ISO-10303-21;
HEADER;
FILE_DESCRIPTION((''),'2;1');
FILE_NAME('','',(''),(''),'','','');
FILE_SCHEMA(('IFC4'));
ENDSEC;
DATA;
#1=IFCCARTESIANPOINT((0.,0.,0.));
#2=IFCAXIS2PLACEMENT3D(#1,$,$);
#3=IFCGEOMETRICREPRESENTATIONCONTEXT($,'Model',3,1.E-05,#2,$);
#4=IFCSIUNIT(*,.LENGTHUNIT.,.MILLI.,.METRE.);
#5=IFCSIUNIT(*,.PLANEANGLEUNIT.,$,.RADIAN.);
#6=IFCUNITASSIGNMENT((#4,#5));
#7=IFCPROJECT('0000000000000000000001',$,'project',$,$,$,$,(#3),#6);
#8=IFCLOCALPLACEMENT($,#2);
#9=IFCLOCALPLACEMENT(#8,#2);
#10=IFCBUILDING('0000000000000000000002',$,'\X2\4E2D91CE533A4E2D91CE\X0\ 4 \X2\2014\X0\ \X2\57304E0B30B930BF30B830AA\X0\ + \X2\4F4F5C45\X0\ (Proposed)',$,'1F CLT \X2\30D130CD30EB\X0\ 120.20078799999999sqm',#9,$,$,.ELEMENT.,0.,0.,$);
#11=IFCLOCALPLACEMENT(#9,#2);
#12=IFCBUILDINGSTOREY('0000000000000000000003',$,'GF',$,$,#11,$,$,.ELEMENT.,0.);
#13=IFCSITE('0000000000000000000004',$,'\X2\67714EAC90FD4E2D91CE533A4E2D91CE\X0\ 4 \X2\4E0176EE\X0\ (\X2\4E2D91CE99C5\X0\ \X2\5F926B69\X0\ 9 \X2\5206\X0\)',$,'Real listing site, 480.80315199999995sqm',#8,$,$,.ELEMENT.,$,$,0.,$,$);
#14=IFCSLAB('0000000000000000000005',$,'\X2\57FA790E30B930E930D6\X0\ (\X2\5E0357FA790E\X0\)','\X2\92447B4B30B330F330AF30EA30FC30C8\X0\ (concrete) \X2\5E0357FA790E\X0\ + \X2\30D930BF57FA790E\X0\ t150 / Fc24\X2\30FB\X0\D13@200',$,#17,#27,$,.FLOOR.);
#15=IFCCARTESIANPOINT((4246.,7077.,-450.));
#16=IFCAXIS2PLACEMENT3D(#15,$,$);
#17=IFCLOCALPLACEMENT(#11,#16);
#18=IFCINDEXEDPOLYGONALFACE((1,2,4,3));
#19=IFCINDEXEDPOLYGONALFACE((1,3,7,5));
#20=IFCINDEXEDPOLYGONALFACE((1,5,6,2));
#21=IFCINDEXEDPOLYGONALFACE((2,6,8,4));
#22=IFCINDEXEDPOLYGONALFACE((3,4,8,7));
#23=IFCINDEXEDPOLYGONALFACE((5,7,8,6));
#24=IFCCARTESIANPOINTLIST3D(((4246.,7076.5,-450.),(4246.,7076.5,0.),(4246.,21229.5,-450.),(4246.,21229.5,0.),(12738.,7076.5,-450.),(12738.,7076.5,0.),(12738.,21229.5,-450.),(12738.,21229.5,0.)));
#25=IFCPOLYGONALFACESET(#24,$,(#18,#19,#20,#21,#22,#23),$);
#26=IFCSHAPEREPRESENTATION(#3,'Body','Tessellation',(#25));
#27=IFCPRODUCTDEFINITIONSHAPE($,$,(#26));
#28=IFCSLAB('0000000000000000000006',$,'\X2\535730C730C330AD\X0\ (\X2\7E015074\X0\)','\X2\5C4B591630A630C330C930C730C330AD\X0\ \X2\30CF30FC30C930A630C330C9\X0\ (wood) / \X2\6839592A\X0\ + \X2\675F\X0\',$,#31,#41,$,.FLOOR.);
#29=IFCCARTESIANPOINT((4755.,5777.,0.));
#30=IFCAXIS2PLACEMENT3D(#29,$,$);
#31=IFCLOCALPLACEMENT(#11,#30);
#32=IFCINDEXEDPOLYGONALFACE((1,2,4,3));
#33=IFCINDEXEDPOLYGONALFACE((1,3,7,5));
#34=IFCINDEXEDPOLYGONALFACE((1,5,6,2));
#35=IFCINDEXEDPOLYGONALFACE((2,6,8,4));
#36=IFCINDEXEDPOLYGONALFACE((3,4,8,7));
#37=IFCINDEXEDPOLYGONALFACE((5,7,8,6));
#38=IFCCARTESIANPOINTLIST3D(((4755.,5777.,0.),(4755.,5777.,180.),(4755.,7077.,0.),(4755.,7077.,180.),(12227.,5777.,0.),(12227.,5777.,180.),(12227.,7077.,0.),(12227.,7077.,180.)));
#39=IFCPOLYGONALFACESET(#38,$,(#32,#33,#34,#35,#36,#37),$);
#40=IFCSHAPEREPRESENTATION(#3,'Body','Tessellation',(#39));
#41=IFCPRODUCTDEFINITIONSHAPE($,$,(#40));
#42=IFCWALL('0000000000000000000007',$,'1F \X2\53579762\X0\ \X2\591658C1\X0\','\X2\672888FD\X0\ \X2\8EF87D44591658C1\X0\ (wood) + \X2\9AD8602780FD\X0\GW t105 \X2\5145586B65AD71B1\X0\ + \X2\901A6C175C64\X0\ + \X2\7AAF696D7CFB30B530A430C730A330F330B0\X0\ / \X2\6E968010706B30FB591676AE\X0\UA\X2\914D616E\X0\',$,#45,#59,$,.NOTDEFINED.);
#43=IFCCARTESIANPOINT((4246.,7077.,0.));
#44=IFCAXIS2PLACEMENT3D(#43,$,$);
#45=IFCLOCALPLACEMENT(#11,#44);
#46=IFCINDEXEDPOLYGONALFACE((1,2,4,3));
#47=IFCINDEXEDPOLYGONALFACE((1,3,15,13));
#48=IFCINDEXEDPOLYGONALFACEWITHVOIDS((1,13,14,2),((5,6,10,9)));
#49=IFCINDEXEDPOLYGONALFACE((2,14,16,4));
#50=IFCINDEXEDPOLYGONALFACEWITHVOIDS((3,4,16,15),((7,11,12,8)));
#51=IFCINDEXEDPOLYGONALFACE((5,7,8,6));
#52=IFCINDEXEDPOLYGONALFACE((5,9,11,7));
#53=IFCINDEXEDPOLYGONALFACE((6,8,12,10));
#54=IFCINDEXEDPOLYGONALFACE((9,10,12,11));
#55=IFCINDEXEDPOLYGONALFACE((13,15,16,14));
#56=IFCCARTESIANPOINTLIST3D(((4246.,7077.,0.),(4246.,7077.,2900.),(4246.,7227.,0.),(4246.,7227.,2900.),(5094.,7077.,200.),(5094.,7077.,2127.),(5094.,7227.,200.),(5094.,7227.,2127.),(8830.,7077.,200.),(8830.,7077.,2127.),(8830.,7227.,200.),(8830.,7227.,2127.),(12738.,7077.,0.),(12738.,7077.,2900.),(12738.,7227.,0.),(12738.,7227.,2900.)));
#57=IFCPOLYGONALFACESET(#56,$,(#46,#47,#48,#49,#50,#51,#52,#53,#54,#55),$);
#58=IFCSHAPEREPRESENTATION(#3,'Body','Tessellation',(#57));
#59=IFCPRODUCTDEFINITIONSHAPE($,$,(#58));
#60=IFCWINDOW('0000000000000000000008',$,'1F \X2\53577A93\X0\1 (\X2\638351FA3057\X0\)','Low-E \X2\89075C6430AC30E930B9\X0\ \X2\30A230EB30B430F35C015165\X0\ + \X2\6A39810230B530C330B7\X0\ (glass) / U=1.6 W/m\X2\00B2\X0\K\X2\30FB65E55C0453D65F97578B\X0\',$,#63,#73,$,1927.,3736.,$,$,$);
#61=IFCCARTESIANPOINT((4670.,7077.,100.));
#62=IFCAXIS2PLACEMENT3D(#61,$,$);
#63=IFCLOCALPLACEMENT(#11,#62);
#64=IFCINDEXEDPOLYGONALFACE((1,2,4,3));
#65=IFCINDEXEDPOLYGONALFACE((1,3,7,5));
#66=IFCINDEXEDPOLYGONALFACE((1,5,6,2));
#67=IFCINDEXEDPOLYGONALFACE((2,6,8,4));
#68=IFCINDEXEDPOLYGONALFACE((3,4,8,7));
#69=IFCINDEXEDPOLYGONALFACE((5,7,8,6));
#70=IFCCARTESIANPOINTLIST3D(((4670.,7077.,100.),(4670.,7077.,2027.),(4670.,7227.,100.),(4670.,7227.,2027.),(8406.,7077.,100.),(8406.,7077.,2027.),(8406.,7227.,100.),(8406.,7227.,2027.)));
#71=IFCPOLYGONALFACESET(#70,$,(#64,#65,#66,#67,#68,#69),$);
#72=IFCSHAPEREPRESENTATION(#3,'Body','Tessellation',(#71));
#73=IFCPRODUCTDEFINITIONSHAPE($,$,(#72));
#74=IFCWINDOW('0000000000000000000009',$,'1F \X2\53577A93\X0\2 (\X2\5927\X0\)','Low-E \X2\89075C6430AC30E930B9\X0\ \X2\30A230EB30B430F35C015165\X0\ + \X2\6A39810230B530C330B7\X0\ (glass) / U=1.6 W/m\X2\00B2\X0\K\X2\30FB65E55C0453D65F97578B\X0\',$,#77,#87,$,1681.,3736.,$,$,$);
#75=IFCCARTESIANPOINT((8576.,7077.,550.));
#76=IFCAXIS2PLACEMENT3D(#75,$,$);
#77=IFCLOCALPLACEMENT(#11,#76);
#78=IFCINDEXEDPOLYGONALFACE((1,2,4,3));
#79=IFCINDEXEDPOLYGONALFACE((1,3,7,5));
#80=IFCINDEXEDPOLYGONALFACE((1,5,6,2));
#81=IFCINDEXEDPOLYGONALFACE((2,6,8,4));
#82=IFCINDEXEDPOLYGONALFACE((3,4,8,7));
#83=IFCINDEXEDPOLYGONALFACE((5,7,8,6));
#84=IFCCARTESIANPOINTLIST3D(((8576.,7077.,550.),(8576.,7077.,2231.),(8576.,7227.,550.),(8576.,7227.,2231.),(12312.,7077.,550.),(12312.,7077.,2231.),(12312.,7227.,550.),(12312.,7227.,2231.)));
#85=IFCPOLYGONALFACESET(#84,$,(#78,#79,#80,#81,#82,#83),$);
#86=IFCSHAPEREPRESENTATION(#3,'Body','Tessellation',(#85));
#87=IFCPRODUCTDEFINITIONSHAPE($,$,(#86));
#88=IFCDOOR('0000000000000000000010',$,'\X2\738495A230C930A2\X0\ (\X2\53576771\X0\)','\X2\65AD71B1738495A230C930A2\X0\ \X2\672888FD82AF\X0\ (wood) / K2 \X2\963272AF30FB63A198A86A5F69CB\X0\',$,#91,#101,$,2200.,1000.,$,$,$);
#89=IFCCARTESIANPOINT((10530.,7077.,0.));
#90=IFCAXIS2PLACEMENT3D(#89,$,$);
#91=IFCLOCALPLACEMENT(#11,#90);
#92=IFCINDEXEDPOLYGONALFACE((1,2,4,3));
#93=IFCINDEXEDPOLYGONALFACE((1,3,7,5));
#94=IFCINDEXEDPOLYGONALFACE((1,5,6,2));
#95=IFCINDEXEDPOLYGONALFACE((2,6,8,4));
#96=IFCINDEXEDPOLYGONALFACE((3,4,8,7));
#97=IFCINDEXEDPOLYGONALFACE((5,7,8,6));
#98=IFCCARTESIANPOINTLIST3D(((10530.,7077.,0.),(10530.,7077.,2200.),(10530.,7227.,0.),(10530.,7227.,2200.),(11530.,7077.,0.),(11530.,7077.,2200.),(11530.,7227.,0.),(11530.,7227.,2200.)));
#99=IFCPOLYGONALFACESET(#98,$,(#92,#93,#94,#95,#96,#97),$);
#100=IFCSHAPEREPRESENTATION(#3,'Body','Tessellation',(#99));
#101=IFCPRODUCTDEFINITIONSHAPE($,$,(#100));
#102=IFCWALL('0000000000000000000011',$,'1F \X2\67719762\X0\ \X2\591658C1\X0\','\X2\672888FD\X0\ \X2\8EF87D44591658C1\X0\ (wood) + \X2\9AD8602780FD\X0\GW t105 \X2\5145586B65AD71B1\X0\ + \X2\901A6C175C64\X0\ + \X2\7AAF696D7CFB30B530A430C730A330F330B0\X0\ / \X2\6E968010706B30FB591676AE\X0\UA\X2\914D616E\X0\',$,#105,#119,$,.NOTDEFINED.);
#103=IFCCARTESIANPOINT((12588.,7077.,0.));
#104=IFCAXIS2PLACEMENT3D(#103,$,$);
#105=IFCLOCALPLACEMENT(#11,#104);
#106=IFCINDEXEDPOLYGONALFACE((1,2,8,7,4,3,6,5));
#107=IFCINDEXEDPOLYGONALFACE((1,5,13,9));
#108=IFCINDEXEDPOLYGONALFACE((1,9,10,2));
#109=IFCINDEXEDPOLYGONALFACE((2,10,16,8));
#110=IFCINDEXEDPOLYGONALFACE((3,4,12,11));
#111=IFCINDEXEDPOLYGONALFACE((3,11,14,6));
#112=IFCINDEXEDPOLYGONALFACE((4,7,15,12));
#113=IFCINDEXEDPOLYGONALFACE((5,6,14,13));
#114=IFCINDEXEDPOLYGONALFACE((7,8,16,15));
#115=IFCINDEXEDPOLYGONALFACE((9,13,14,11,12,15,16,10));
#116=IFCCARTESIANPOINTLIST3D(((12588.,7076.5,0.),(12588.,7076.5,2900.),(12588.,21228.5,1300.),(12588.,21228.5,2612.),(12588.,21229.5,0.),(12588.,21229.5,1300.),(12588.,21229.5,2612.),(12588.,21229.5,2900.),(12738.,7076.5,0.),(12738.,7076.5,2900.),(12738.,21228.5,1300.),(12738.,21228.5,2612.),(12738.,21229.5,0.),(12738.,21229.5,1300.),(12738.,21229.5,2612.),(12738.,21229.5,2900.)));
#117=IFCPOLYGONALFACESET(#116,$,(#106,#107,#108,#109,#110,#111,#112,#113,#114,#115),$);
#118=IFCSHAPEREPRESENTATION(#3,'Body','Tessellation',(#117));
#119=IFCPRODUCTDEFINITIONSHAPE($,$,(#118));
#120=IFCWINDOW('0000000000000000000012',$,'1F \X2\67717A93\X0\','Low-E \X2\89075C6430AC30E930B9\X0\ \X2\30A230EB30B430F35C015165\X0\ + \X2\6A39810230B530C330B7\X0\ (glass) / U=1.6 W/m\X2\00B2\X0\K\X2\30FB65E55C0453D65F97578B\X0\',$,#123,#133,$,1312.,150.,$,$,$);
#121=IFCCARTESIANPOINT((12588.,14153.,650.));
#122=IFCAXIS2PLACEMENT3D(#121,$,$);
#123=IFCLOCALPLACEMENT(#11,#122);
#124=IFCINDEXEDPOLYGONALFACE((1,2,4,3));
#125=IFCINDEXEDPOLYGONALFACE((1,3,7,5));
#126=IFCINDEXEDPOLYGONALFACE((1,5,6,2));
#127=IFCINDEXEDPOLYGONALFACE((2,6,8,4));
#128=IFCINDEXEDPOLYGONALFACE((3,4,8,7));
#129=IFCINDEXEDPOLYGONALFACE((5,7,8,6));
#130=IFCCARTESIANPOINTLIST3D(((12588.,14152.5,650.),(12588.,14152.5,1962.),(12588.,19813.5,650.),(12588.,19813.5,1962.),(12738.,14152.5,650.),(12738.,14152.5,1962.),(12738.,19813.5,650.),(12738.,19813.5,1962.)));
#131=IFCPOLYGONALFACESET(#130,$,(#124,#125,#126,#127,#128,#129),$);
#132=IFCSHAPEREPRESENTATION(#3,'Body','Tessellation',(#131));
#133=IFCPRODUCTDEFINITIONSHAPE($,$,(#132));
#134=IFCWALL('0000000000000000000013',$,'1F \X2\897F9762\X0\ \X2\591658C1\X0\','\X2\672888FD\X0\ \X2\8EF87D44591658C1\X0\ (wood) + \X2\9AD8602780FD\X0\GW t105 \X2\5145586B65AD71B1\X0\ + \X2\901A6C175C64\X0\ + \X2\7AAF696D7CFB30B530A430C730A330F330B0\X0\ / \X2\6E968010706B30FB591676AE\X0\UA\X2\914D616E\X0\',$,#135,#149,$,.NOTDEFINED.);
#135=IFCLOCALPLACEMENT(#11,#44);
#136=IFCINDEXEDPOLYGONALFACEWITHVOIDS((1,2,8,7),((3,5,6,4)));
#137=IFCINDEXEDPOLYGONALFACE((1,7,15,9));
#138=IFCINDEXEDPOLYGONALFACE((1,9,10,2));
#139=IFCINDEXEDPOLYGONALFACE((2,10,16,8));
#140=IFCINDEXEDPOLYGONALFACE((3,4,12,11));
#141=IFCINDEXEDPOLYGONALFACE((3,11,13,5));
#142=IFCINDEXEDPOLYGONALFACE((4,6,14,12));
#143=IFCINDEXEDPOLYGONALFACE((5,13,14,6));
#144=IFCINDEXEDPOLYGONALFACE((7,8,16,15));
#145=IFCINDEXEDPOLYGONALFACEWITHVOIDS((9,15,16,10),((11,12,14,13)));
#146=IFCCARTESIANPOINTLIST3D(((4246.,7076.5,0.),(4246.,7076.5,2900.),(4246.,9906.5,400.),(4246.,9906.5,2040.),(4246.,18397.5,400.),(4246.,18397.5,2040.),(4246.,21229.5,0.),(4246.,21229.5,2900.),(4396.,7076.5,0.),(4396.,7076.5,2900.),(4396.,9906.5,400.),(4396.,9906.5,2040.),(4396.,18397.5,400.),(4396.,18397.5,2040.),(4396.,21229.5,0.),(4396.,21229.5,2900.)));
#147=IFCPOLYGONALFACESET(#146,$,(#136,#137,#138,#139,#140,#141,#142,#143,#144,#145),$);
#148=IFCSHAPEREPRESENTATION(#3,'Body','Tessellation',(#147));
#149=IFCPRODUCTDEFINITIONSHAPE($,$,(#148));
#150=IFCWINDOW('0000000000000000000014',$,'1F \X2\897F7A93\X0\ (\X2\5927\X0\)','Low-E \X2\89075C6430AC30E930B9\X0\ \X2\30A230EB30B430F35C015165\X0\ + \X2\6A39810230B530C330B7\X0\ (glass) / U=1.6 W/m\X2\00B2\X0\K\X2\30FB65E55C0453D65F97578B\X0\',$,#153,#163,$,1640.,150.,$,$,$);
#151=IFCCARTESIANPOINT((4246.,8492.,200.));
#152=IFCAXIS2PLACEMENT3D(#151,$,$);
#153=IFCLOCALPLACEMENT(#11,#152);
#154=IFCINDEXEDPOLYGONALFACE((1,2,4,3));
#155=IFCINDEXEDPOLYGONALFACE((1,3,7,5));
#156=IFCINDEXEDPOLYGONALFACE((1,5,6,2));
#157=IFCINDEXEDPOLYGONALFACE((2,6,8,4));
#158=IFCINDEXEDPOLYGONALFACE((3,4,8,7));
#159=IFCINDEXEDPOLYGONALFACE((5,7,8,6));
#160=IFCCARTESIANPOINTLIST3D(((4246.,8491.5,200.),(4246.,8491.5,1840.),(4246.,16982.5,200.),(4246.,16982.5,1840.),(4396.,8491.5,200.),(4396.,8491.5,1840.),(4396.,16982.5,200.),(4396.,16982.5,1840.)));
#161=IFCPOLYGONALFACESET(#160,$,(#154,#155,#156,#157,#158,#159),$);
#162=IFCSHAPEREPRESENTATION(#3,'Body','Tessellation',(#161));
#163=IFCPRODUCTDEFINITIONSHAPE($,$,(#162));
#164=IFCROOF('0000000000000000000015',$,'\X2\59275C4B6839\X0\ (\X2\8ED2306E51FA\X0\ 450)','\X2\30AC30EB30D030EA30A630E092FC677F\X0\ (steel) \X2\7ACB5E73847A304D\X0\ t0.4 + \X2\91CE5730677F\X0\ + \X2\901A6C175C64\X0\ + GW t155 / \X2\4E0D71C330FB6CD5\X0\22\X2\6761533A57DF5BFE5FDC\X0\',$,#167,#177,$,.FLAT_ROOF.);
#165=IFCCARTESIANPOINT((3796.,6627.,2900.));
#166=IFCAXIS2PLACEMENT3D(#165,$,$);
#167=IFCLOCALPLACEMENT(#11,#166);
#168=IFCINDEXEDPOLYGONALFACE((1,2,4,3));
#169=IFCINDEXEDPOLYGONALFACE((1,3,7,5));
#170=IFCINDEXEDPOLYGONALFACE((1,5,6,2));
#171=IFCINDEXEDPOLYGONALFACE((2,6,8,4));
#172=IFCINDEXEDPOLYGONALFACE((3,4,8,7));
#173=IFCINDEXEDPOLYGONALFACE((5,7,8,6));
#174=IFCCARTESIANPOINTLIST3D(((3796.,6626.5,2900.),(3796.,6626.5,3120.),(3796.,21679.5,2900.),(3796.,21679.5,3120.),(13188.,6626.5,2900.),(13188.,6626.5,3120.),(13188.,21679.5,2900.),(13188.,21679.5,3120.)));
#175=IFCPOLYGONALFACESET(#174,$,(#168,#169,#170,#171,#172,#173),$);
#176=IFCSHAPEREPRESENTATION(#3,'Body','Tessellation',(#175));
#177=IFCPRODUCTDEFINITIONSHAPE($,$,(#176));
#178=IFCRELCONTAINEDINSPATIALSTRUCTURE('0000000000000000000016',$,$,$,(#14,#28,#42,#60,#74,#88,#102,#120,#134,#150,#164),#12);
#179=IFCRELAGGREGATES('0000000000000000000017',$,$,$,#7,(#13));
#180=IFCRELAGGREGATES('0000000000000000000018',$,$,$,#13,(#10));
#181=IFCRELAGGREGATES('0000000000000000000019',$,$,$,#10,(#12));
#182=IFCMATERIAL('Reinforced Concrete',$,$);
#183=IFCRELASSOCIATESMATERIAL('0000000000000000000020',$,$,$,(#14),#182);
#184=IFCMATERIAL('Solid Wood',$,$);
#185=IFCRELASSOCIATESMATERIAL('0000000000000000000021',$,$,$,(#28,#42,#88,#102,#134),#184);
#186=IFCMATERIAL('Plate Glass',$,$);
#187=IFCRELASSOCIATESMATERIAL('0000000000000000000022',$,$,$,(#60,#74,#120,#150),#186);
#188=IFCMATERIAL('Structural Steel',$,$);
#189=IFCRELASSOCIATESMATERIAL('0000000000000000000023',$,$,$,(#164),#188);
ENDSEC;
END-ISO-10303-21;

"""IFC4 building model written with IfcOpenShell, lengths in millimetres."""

from ifc_helpers import new_model, si_unit, frame, frame_2d, origin, place, context, project, spatial, rectangle, extrude, material, element, fill, save


model = new_model("IFC4")

# Units and contexts
model_context = context("Model", 3, precision=1e-05, world=origin())
ifc_project = project(units=[si_unit("LENGTHUNIT", "METRE", prefix="MILLI"), si_unit("PLANEANGLEUNIT", "RADIAN")], contexts=[model_context])

# Site, building, storey
site_placement = place(None, origin())
site = spatial("IfcSite", under=ifc_project, at=site_placement, Name="東京都中野区中野 4 丁目 (中野駅 徒歩 9 分)", ObjectType="Real listing site, 480.80315199999995sqm", CompositionType="ELEMENT", RefElevation=0.0)
building_placement = place(site_placement, origin())
building = spatial("IfcBuilding", under=site, at=building_placement, Name="中野区中野 4 — 地下スタジオ + 住居 (Proposed)", ObjectType="1F CLT パネル 120.20078799999999sqm", CompositionType="ELEMENT", ElevationOfRefHeight=0.0, ElevationOfTerrain=0.0)
storey_placement = place(building_placement, origin())
storey = spatial("IfcBuildingStorey", under=building, at=storey_placement, Name="GF", CompositionType="ELEMENT", Elevation=0.0)

# Slabs
ifc_material_1 = material(Name="Reinforced Concrete")
slab_1_placement = place(storey_placement, frame((4246.0, 7077.0, -450.0)))
element("IfcSlab", 1, at=slab_1_placement, inside=storey, material=ifc_material_1, Name="基礎スラブ (布基礎)", Description="鉄筋コンクリート (concrete) 布基礎 + ベタ基礎 t150 / Fc24・D13@200", PredefinedType="FLOOR", context=model_context, shape_type="SweptSolid", body=[
    extrude(rectangle(XDim=8492.0, YDim=14153.0, at=frame_2d((4246.0, 7076.0))), frame((4246.0, 7077.0, -450.0)), (0.0, 0.0, 1.0), 450.0),
])
ifc_material_2 = material(Name="Solid Wood")
slab_2_placement = place(storey_placement, frame((4755.0, 5777.0, 0.0)))
element("IfcSlab", 2, at=slab_2_placement, inside=storey, material=ifc_material_2, Name="南デッキ (縁側)", Description="屋外ウッドデッキ ハードウッド (wood) / 根太 + 束", PredefinedType="FLOOR", context=model_context, shape_type="SweptSolid", body=[
    extrude(rectangle(XDim=7472.0, YDim=1300.0, at=frame_2d((3736.0, 650.0))), frame((4755.0, 5777.0, 0.0)), (0.0, 0.0, 1.0), 180.0),
])

# Wall, openings, windows, door
wall_1_placement = place(storey_placement, frame((4246.0, 7077.0, 0.0)))
wall_1 = element("IfcWall", 3, at=wall_1_placement, inside=storey, material=ifc_material_2, Name="1F 南面 外壁", Description="木製 軸組外壁 (wood) + 高性能GW t105 充填断熱 + 通気層 + 窯業系サイディング / 準耐火・外皮UA配慮", PredefinedType="NOTDEFINED", context=model_context, shape_type="SweptSolid", body=[
    extrude(rectangle(XDim=8492.0, YDim=150.0, at=frame_2d((4246.0, 75.0))), frame((4246.0, 7077.0, 0.0)), (0.0, 0.0, 1.0), 2900.0),
])
opening_1_placement = place(storey_placement, frame((4670.0, 7077.0, 100.0)))
opening_1 = element("IfcOpeningElement", 4, at=opening_1_placement, cuts=wall_1, PredefinedType="NOTDEFINED", context=model_context, shape_type="SweptSolid", body=[
    extrude(rectangle(XDim=3736.0, YDim=150.0, at=frame_2d((1868.0, 75.0))), frame((4670.0, 7077.0, 100.0)), (0.0, 0.0, 1.0), 1927.0),
])
opening_2_placement = place(storey_placement, frame((8576.0, 7077.0, 550.0)))
opening_2 = element("IfcOpeningElement", 5, at=opening_2_placement, cuts=wall_1, PredefinedType="NOTDEFINED", context=model_context, shape_type="SweptSolid", body=[
    extrude(rectangle(XDim=3736.0, YDim=150.0, at=frame_2d((1868.0, 75.0))), frame((8576.0, 7077.0, 550.0)), (0.0, 0.0, 1.0), 1681.0),
])
opening_3_placement = place(storey_placement, frame((10530.0, 7077.0, 0.0)))
opening_3 = element("IfcOpeningElement", 6, at=opening_3_placement, cuts=wall_1, PredefinedType="NOTDEFINED", context=model_context, shape_type="SweptSolid", body=[
    extrude(rectangle(XDim=1000.0, YDim=150.0, at=frame_2d((500.0, 75.0))), frame((10530.0, 7077.0, 0.0)), (0.0, 0.0, 1.0), 2200.0),
])
ifc_material_3 = material(Name="Plate Glass")
window_1_placement = place(storey_placement, frame((4670.0, 7077.0, 100.0)))
window_1 = element("IfcWindow", 7, at=window_1_placement, inside=storey, material=ifc_material_3, Name="1F 南窓1 (掃出し)", Description="Low-E 複層ガラス アルゴン封入 + 樹脂サッシ (glass) / U=1.6 W/m²K・日射取得型", OverallHeight=1927.0, OverallWidth=3736.0, context=model_context, shape_type="SweptSolid", body=[
    extrude(rectangle(XDim=3736.0, YDim=150.0, at=frame_2d((1868.0, 75.0))), frame((4670.0, 7077.0, 100.0)), (0.0, 0.0, 1.0), 1927.0),
])
fill(opening_1, window_1)
window_2_placement = place(storey_placement, frame((8576.0, 7077.0, 550.0)))
window_2 = element("IfcWindow", 8, at=window_2_placement, inside=storey, material=ifc_material_3, Name="1F 南窓2 (大)", Description="Low-E 複層ガラス アルゴン封入 + 樹脂サッシ (glass) / U=1.6 W/m²K・日射取得型", OverallHeight=1681.0, OverallWidth=3736.0, context=model_context, shape_type="SweptSolid", body=[
    extrude(rectangle(XDim=3736.0, YDim=150.0, at=frame_2d((1868.0, 75.0))), frame((8576.0, 7077.0, 550.0)), (0.0, 0.0, 1.0), 1681.0),
])
fill(opening_2, window_2)
door_placement = place(storey_placement, frame((10530.0, 7077.0, 0.0)))
door = element("IfcDoor", 9, at=door_placement, inside=storey, material=ifc_material_2, Name="玄関ドア (南東)", Description="断熱玄関ドア 木製芯 (wood) / K2 防犯・採風機構", OverallHeight=2200.0, OverallWidth=1000.0, context=model_context, shape_type="SweptSolid", body=[
    extrude(rectangle(XDim=1000.0, YDim=150.0, at=frame_2d((500.0, 75.0))), frame((10530.0, 7077.0, 0.0)), (0.0, 0.0, 1.0), 2200.0),
])
fill(opening_3, door)

# Walls, openings, windows
wall_2_placement = place(storey_placement, frame((12588.0, 7077.0, 0.0)))
wall_2 = element("IfcWall", 10, at=wall_2_placement, inside=storey, material=ifc_material_2, Name="1F 東面 外壁", Description="木製 軸組外壁 (wood) + 高性能GW t105 充填断熱 + 通気層 + 窯業系サイディング / 準耐火・外皮UA配慮", PredefinedType="NOTDEFINED", context=model_context, shape_type="SweptSolid", body=[
    extrude(rectangle(XDim=150.0, YDim=14153.0, at=frame_2d((75.0, 7076.0))), frame((12588.0, 7077.0, 0.0)), (0.0, 0.0, 1.0), 2900.0),
])
opening_4_placement = place(storey_placement, frame((12588.0, 14153.0, 650.0)))
opening_4 = element("IfcOpeningElement", 11, at=opening_4_placement, cuts=wall_2, PredefinedType="NOTDEFINED", context=model_context, shape_type="SweptSolid", body=[
    extrude(rectangle(XDim=150.0, YDim=5661.0, at=frame_2d((75.0, 2830.0))), frame((12588.0, 14153.0, 650.0)), (0.0, 0.0, 1.0), 1312.0),
])
window_3_placement = place(storey_placement, frame((12588.0, 14153.0, 650.0)))
window_3 = element("IfcWindow", 12, at=window_3_placement, inside=storey, material=ifc_material_3, Name="1F 東窓", Description="Low-E 複層ガラス アルゴン封入 + 樹脂サッシ (glass) / U=1.6 W/m²K・日射取得型", OverallHeight=1312.0, OverallWidth=150.0, context=model_context, shape_type="SweptSolid", body=[
    extrude(rectangle(XDim=150.0, YDim=5661.0, at=frame_2d((75.0, 2830.0))), frame((12588.0, 14153.0, 650.0)), (0.0, 0.0, 1.0), 1312.0),
])
fill(opening_4, window_3)
wall_3_placement = place(storey_placement, frame((4246.0, 7077.0, 0.0)))
wall_3 = element("IfcWall", 13, at=wall_3_placement, inside=storey, material=ifc_material_2, Name="1F 西面 外壁", Description="木製 軸組外壁 (wood) + 高性能GW t105 充填断熱 + 通気層 + 窯業系サイディング / 準耐火・外皮UA配慮", PredefinedType="NOTDEFINED", context=model_context, shape_type="SweptSolid", body=[
    extrude(rectangle(XDim=150.0, YDim=14153.0, at=frame_2d((75.0, 7076.0))), frame((4246.0, 7077.0, 0.0)), (0.0, 0.0, 1.0), 2900.0),
])
opening_5_placement = place(storey_placement, frame((4246.0, 8492.0, 200.0)))
opening_5 = element("IfcOpeningElement", 14, at=opening_5_placement, cuts=wall_3, PredefinedType="NOTDEFINED", context=model_context, shape_type="SweptSolid", body=[
    extrude(rectangle(XDim=150.0, YDim=8491.0, at=frame_2d((75.0, 4245.0))), frame((4246.0, 8492.0, 200.0)), (0.0, 0.0, 1.0), 1640.0),
])
window_4_placement = place(storey_placement, frame((4246.0, 8492.0, 200.0)))
window_4 = element("IfcWindow", 15, at=window_4_placement, inside=storey, material=ifc_material_3, Name="1F 西窓 (大)", Description="Low-E 複層ガラス アルゴン封入 + 樹脂サッシ (glass) / U=1.6 W/m²K・日射取得型", OverallHeight=1640.0, OverallWidth=150.0, context=model_context, shape_type="SweptSolid", body=[
    extrude(rectangle(XDim=150.0, YDim=8491.0, at=frame_2d((75.0, 4245.0))), frame((4246.0, 8492.0, 200.0)), (0.0, 0.0, 1.0), 1640.0),
])
fill(opening_5, window_4)

# Roof
ifc_material_4 = material(Name="Structural Steel")
roof_placement = place(storey_placement, frame((3796.0, 6627.0, 2900.0)))
element("IfcRoof", 16, at=roof_placement, inside=storey, material=ifc_material_4, Name="大屋根 (軒の出 450)", Description="ガルバリウム鋼板 (steel) 立平葺き t0.4 + 野地板 + 通気層 + GW t155 / 不燃・法22条区域対応", PredefinedType="FLAT_ROOF", context=model_context, shape_type="SweptSolid", body=[
    extrude(rectangle(XDim=9392.0, YDim=15053.0, at=frame_2d((4696.0, 7526.0))), frame((3796.0, 6627.0, 2900.0)), (0.0, 0.0, 1.0), 220.0),
])

save(model, "model.ifc")
